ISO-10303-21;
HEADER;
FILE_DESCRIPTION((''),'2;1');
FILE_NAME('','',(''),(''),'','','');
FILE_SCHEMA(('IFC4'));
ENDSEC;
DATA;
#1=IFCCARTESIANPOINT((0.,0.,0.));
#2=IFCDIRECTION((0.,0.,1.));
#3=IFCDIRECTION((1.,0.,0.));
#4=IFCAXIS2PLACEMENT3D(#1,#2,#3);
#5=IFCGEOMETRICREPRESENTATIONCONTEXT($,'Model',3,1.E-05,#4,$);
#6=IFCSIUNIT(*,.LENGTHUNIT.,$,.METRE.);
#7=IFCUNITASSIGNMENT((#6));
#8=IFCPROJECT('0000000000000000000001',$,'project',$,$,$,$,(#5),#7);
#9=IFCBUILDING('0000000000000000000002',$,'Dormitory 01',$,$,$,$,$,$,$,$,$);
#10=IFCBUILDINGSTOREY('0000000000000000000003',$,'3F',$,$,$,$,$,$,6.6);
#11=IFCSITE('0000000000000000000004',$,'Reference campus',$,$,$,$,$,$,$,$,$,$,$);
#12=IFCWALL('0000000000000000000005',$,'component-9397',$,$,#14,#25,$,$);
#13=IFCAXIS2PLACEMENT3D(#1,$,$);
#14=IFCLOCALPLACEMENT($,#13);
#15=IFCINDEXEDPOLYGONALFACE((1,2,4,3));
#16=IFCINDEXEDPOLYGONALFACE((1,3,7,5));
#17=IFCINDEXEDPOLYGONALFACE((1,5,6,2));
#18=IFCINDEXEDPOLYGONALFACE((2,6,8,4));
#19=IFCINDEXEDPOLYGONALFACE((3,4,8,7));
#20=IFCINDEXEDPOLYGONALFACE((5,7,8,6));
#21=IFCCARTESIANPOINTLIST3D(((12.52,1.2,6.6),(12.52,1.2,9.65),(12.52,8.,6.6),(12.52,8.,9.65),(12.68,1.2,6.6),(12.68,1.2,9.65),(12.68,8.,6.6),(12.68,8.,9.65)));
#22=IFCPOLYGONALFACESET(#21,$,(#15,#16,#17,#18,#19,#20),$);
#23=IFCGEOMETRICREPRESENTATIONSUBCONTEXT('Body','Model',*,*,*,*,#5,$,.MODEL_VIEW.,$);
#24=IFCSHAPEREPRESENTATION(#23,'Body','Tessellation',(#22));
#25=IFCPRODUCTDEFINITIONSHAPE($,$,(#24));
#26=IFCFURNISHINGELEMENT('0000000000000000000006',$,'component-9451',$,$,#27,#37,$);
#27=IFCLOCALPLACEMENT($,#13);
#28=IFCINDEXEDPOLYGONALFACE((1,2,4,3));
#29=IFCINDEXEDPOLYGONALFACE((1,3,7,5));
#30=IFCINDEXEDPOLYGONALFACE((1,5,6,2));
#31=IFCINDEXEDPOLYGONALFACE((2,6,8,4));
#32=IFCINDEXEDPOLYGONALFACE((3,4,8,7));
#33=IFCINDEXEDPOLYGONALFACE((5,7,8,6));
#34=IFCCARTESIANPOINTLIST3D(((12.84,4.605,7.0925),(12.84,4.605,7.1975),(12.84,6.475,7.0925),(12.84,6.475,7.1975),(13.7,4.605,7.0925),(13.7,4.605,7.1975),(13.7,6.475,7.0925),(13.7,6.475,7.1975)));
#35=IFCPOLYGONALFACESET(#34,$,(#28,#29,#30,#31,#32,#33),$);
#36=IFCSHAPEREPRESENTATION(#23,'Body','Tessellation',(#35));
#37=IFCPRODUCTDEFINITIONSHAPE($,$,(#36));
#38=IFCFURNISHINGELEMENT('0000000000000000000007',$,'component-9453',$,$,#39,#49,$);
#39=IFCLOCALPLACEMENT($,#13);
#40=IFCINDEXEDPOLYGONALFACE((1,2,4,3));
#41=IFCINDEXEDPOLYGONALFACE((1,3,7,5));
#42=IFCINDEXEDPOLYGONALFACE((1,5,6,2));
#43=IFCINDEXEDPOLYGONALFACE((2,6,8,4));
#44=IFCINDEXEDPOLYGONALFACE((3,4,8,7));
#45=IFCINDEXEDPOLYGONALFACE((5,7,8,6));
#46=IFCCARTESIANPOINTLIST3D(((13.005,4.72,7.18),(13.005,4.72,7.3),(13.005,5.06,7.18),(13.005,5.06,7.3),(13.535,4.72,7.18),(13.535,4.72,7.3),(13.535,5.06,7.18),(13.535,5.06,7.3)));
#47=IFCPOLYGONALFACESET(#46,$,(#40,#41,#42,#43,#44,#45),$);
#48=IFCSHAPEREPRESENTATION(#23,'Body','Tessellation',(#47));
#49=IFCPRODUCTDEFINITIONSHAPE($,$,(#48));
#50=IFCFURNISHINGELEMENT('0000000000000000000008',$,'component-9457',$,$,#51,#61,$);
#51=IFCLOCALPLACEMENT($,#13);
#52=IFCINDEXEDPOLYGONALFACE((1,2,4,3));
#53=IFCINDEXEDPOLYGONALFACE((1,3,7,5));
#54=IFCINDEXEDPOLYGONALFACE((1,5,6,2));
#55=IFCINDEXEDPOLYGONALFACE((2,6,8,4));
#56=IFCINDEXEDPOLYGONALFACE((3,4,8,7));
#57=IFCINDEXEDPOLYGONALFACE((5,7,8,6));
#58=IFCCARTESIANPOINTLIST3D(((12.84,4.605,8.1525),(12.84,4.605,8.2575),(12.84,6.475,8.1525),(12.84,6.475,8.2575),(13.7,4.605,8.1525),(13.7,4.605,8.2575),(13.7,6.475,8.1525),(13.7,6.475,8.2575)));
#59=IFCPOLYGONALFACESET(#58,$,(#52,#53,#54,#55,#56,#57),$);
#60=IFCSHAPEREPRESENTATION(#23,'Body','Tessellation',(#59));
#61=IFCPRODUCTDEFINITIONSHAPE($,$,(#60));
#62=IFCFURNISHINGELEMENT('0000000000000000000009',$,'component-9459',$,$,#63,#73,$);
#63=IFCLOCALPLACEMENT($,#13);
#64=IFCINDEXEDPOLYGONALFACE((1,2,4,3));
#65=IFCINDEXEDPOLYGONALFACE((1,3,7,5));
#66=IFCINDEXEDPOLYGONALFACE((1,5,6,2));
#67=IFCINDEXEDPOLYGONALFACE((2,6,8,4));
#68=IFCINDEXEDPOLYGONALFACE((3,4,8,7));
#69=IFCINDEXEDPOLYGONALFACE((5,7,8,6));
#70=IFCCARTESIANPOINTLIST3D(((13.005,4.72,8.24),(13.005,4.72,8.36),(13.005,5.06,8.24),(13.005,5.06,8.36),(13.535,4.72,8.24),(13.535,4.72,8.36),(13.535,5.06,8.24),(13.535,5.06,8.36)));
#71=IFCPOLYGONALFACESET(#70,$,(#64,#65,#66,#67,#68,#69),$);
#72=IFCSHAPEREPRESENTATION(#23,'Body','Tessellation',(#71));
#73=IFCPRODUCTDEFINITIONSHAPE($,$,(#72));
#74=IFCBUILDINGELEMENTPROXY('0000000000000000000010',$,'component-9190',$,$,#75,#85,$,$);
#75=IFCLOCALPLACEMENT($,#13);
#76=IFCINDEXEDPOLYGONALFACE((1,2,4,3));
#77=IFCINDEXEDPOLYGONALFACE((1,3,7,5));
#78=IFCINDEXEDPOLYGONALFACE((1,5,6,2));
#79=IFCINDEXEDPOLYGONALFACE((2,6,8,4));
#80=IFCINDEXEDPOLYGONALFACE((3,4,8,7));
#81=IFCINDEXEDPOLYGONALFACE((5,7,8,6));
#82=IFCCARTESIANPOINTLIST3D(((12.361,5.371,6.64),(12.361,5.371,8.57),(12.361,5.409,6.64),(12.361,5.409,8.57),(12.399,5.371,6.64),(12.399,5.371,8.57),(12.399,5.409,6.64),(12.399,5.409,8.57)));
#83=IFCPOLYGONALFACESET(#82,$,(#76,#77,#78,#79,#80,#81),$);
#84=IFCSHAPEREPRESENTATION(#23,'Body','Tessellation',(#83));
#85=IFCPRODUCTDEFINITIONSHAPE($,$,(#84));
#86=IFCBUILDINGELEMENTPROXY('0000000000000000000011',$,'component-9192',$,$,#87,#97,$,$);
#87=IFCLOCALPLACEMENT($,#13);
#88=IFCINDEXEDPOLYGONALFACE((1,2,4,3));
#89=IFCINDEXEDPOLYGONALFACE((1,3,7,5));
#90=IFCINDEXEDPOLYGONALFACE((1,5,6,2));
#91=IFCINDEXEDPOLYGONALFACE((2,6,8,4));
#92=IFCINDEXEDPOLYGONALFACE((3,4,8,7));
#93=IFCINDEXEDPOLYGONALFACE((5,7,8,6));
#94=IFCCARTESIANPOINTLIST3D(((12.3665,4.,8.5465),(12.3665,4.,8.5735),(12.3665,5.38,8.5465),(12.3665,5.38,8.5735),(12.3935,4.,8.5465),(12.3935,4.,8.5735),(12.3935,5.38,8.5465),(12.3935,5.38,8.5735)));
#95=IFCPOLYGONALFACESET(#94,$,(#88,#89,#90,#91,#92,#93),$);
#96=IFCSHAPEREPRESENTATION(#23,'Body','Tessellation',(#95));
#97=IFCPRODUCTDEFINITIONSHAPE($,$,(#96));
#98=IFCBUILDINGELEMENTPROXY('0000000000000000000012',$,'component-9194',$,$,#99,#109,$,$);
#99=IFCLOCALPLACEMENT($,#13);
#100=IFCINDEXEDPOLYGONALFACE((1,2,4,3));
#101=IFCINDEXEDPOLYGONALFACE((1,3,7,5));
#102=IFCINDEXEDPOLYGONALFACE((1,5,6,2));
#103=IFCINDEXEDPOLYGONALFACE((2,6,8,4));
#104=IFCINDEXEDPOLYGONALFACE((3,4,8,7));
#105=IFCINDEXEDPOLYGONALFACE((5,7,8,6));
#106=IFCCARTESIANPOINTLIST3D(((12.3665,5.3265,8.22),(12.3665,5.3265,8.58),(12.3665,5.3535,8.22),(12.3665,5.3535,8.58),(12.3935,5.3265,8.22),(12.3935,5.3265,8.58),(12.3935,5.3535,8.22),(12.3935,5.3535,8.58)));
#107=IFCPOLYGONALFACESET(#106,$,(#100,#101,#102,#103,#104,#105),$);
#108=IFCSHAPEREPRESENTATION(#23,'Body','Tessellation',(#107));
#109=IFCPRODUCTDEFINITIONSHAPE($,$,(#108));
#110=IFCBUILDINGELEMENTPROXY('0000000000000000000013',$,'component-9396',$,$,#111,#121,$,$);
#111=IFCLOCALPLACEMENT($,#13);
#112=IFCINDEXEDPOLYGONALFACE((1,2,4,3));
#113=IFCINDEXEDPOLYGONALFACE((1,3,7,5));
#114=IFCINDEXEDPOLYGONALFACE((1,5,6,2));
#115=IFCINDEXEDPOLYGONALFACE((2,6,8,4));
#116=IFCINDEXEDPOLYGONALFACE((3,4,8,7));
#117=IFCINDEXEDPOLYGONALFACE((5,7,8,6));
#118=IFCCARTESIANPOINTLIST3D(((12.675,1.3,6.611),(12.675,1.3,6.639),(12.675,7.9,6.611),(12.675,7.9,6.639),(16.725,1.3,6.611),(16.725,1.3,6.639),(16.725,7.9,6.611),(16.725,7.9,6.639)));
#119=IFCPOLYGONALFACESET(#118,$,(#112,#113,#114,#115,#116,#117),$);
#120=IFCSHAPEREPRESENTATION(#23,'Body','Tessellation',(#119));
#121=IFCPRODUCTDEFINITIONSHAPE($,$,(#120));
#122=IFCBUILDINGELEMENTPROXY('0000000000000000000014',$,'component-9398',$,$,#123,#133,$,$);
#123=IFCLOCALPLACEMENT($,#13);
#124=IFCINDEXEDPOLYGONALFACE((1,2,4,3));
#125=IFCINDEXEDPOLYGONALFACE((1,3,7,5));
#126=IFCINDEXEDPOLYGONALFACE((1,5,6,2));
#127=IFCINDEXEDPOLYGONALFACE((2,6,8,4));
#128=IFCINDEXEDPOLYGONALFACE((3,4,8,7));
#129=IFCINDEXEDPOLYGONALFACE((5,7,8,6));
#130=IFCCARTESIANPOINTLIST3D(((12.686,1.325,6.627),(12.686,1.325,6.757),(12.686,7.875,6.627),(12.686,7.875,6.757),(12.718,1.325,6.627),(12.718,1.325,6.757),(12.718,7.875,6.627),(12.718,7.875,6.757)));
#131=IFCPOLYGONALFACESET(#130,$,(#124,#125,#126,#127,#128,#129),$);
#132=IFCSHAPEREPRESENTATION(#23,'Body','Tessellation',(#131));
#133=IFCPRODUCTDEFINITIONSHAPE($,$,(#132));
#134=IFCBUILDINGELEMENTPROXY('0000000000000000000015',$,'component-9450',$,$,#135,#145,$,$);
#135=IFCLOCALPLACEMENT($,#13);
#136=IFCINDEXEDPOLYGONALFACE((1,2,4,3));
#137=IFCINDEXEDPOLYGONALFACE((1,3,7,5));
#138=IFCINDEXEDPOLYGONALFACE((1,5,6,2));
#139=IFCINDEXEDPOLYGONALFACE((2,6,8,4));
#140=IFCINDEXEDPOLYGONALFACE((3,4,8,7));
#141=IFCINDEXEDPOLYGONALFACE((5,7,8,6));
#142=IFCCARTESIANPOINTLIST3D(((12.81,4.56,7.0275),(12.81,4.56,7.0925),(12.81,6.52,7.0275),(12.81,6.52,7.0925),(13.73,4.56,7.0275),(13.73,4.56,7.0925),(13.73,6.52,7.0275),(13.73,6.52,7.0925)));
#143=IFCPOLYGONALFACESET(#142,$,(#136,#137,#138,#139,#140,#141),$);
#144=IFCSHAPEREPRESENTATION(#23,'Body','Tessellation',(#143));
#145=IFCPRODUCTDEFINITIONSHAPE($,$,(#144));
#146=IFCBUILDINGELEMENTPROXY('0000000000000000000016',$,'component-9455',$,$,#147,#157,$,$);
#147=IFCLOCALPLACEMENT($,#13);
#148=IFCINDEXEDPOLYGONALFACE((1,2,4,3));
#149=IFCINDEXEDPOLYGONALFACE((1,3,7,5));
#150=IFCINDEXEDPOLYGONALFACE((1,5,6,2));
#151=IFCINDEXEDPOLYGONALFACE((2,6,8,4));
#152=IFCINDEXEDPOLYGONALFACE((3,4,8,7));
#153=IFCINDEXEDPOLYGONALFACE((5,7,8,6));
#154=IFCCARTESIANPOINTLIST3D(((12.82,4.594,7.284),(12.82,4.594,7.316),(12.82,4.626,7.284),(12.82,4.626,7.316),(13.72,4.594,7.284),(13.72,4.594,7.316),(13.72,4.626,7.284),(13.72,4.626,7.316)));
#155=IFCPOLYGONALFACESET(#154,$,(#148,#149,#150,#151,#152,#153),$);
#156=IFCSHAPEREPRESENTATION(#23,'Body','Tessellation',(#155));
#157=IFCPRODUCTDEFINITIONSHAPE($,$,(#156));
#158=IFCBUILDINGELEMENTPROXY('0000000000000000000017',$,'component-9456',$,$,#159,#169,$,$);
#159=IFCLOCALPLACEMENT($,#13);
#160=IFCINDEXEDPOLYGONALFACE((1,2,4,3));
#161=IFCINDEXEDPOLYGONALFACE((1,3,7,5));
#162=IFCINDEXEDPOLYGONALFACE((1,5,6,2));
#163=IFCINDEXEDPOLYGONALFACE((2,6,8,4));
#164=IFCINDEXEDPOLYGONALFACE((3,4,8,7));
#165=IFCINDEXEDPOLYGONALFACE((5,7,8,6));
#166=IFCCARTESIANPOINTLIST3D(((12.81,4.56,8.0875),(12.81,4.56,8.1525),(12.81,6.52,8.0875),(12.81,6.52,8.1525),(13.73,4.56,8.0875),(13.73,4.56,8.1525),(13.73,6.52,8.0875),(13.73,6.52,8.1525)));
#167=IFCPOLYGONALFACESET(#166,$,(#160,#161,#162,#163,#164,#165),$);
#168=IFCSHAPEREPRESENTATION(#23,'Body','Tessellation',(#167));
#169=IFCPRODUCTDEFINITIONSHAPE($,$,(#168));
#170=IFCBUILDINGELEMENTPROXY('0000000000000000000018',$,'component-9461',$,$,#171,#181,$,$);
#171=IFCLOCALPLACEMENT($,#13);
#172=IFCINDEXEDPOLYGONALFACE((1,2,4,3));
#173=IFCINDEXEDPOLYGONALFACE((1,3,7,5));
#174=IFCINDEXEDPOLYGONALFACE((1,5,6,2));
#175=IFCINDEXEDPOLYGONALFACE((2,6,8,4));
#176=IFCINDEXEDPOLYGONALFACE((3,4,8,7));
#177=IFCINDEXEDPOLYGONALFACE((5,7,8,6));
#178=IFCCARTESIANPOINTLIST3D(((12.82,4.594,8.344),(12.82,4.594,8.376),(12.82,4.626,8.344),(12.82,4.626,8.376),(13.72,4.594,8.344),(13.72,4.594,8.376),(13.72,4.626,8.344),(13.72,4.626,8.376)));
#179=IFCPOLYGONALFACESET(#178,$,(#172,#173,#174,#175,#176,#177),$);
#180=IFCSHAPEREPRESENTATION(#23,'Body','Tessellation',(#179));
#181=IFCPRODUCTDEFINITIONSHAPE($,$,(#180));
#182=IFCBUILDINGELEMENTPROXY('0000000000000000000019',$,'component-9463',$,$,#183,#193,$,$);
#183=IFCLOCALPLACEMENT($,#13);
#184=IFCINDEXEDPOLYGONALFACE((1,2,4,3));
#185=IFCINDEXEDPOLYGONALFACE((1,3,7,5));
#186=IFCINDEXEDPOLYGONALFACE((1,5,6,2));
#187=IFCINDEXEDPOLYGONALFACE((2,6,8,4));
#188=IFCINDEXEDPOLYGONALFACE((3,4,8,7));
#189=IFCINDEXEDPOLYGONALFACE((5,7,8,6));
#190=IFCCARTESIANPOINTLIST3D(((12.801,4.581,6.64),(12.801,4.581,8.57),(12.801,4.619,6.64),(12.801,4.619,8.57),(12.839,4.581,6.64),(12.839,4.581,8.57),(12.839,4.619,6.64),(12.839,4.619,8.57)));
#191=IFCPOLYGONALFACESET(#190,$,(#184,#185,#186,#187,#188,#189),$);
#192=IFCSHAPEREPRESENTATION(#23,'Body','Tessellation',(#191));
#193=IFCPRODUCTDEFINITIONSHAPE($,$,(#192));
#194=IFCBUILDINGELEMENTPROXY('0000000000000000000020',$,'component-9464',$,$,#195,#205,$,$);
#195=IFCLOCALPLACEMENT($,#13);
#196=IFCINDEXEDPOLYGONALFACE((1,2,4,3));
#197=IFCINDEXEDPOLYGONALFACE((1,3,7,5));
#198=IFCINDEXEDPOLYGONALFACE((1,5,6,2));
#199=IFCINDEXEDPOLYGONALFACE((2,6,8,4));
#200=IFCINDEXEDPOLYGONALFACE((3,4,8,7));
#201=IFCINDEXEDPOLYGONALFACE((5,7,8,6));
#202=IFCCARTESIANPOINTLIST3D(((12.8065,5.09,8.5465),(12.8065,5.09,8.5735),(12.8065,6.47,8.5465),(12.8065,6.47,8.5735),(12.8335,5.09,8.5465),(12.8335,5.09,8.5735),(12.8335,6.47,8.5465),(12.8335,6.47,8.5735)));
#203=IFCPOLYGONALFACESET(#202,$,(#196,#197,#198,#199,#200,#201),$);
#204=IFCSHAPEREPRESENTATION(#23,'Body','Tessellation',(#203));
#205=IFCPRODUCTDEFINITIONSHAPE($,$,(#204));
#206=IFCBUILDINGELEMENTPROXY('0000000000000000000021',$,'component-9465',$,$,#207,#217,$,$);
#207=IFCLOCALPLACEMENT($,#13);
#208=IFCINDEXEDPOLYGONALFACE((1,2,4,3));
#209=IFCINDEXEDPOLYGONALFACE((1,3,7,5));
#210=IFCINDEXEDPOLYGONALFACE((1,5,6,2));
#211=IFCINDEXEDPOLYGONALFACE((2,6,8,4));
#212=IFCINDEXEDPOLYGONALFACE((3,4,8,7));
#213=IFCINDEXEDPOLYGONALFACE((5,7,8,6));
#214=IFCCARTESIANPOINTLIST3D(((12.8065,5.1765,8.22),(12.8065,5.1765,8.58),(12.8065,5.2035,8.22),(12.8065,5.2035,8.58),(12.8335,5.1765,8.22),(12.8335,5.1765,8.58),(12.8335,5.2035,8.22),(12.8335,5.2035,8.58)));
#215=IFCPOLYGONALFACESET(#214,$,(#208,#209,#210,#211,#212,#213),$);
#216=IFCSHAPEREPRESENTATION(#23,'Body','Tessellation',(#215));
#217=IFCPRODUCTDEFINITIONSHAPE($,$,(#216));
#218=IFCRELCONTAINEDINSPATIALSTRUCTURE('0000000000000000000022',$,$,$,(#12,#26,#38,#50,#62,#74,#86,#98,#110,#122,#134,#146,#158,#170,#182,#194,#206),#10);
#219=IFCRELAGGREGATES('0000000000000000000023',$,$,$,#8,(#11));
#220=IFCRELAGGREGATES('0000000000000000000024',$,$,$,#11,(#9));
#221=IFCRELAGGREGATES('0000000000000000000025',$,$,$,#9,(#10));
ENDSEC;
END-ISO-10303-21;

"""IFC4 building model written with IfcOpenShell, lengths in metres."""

from ifc_helpers import new_model, si_unit, frame, origin, origin_with_axes, origin_2d, place, context, subcontext, project, spatial, rectangle, extrude, element, save


model = new_model("IFC4")

# Units and contexts
model_context = context("Model", 3, precision=1e-05, world=origin_with_axes())
body_context = subcontext(model_context, "Body", "Model", "MODEL_VIEW")
ifc_project = project(units=[si_unit("LENGTHUNIT", "METRE")], contexts=[model_context])

# Site, building, storey
site = spatial("IfcSite", under=ifc_project, Name="Reference campus")
building = spatial("IfcBuilding", under=site, Name="Dormitory 01")
storey = spatial("IfcBuildingStorey", under=building, Name="3F", Elevation=6.6)

# Wall
wall_placement = place(None, frame((12.6, 4.6, 6.6), z_axis=(0.0, 0.0, 1.0), x_axis=(1.0, 0.0, 0.0)))
element("IfcWall", 1, at=wall_placement, inside=storey, Name="component-9397", context=body_context, shape_type="SweptSolid", body=[
    extrude(rectangle(XDim=0.16, YDim=6.8, at=origin_2d()), origin(), (0.0, 0.0, 1.0), 3.05),
])

# Furnishing elements
furnishing_1_placement = place(None, frame((13.27, 5.54, 7.0925), z_axis=(0.0, 0.0, 1.0), x_axis=(1.0, 0.0, 0.0)))
element("IfcFurnishingElement", 2, at=furnishing_1_placement, inside=storey, Name="component-9451", context=body_context, shape_type="SweptSolid", body=[
    extrude(rectangle(XDim=0.86, YDim=1.87, at=origin_2d()), origin(), (0.0, 0.0, 1.0), 0.105),
])
furnishing_2_placement = place(None, frame((13.27, 4.89, 7.18), z_axis=(0.0, 0.0, 1.0), x_axis=(1.0, 0.0, 0.0)))
element("IfcFurnishingElement", 3, at=furnishing_2_placement, inside=storey, Name="component-9453", context=body_context, shape_type="SweptSolid", body=[
    extrude(rectangle(XDim=0.53, YDim=0.34, at=origin_2d()), origin(), (0.0, 0.0, 1.0), 0.12),
])
furnishing_3_placement = place(None, frame((13.27, 5.54, 8.1525), z_axis=(0.0, 0.0, 1.0), x_axis=(1.0, 0.0, 0.0)))
element("IfcFurnishingElement", 4, at=furnishing_3_placement, inside=storey, Name="component-9457", context=body_context, shape_type="SweptSolid", body=[
    extrude(rectangle(XDim=0.86, YDim=1.87, at=origin_2d()), origin(), (0.0, 0.0, 1.0), 0.105),
])
furnishing_4_placement = place(None, frame((13.27, 4.89, 8.24), z_axis=(0.0, 0.0, 1.0), x_axis=(1.0, 0.0, 0.0)))
element("IfcFurnishingElement", 5, at=furnishing_4_placement, inside=storey, Name="component-9459", context=body_context, shape_type="SweptSolid", body=[
    extrude(rectangle(XDim=0.53, YDim=0.34, at=origin_2d()), origin(), (0.0, 0.0, 1.0), 0.12),
])

# Building element proxies
proxy_1_placement = place(None, frame((12.38, 5.39, 6.64), z_axis=(0.0, 0.0, 1.0), x_axis=(1.0, 0.0, 0.0)))
element("IfcBuildingElementProxy", 6, at=proxy_1_placement, inside=storey, Name="component-9190", context=body_context, shape_type="SweptSolid", body=[
    extrude(rectangle(XDim=0.038, YDim=0.038, at=origin_2d()), origin(), (0.0, 0.0, 1.0), 1.93),
])
proxy_2_placement = place(None, frame((12.38, 4.69, 8.5465), z_axis=(0.0, 0.0, 1.0), x_axis=(1.0, 0.0, 0.0)))
element("IfcBuildingElementProxy", 7, at=proxy_2_placement, inside=storey, Name="component-9192", context=body_context, shape_type="SweptSolid", body=[
    extrude(rectangle(XDim=0.027, YDim=1.38, at=origin_2d()), origin(), (0.0, 0.0, 1.0), 0.027),
])
proxy_3_placement = place(None, frame((12.38, 5.34, 8.22), z_axis=(0.0, 0.0, 1.0), x_axis=(1.0, 0.0, 0.0)))
element("IfcBuildingElementProxy", 8, at=proxy_3_placement, inside=storey, Name="component-9194", context=body_context, shape_type="SweptSolid", body=[
    extrude(rectangle(XDim=0.027, YDim=0.027, at=origin_2d()), origin(), (0.0, 0.0, 1.0), 0.36),
])
proxy_4_placement = place(None, frame((14.7, 4.6, 6.611), z_axis=(0.0, 0.0, 1.0), x_axis=(1.0, 0.0, 0.0)))
element("IfcBuildingElementProxy", 9, at=proxy_4_placement, inside=storey, Name="component-9396", context=body_context, shape_type="SweptSolid", body=[
    extrude(rectangle(XDim=4.05, YDim=6.6, at=origin_2d()), origin(), (0.0, 0.0, 1.0), 0.028),
])
proxy_5_placement = place(None, frame((12.702, 4.6, 6.627), z_axis=(0.0, 0.0, 1.0), x_axis=(1.0, 0.0, 0.0)))
element("IfcBuildingElementProxy", 10, at=proxy_5_placement, inside=storey, Name="component-9398", context=body_context, shape_type="SweptSolid", body=[
    extrude(rectangle(XDim=0.032, YDim=6.55, at=origin_2d()), origin(), (0.0, 0.0, 1.0), 0.13),
])
proxy_6_placement = place(None, frame((13.27, 5.54, 7.0275), z_axis=(0.0, 0.0, 1.0), x_axis=(1.0, 0.0, 0.0)))
element("IfcBuildingElementProxy", 11, at=proxy_6_placement, inside=storey, Name="component-9450", context=body_context, shape_type="SweptSolid", body=[
    extrude(rectangle(XDim=0.92, YDim=1.96, at=origin_2d()), origin(), (0.0, 0.0, 1.0), 0.065),
])
proxy_7_placement = place(None, frame((13.27, 4.61, 7.284), z_axis=(0.0, 0.0, 1.0), x_axis=(1.0, 0.0, 0.0)))
element("IfcBuildingElementProxy", 12, at=proxy_7_placement, inside=storey, Name="component-9455", context=body_context, shape_type="SweptSolid", body=[
    extrude(rectangle(XDim=0.9, YDim=0.032, at=origin_2d()), origin(), (0.0, 0.0, 1.0), 0.032),
])
proxy_8_placement = place(None, frame((13.27, 5.54, 8.0875), z_axis=(0.0, 0.0, 1.0), x_axis=(1.0, 0.0, 0.0)))
element("IfcBuildingElementProxy", 13, at=proxy_8_placement, inside=storey, Name="component-9456", context=body_context, shape_type="SweptSolid", body=[
    extrude(rectangle(XDim=0.92, YDim=1.96, at=origin_2d()), origin(), (0.0, 0.0, 1.0), 0.065),
])
proxy_9_placement = place(None, frame((13.27, 4.61, 8.344), z_axis=(0.0, 0.0, 1.0), x_axis=(1.0, 0.0, 0.0)))
element("IfcBuildingElementProxy", 14, at=proxy_9_placement, inside=storey, Name="component-9461", context=body_context, shape_type="SweptSolid", body=[
    extrude(rectangle(XDim=0.9, YDim=0.032, at=origin_2d()), origin(), (0.0, 0.0, 1.0), 0.032),
])
proxy_10_placement = place(None, frame((12.82, 4.6, 6.64), z_axis=(0.0, 0.0, 1.0), x_axis=(1.0, 0.0, 0.0)))
element("IfcBuildingElementProxy", 15, at=proxy_10_placement, inside=storey, Name="component-9463", context=body_context, shape_type="SweptSolid", body=[
    extrude(rectangle(XDim=0.038, YDim=0.038, at=origin_2d()), origin(), (0.0, 0.0, 1.0), 1.93),
])
proxy_11_placement = place(None, frame((12.82, 5.78, 8.5465), z_axis=(0.0, 0.0, 1.0), x_axis=(1.0, 0.0, 0.0)))
element("IfcBuildingElementProxy", 16, at=proxy_11_placement, inside=storey, Name="component-9464", context=body_context, shape_type="SweptSolid", body=[
    extrude(rectangle(XDim=0.027, YDim=1.38, at=origin_2d()), origin(), (0.0, 0.0, 1.0), 0.027),
])
proxy_12_placement = place(None, frame((12.82, 5.19, 8.22), z_axis=(0.0, 0.0, 1.0), x_axis=(1.0, 0.0, 0.0)))
element("IfcBuildingElementProxy", 17, at=proxy_12_placement, inside=storey, Name="component-9465", context=body_context, shape_type="SweptSolid", body=[
    extrude(rectangle(XDim=0.027, YDim=0.027, at=origin_2d()), origin(), (0.0, 0.0, 1.0), 0.36),
])

save(model, "model.ifc")
